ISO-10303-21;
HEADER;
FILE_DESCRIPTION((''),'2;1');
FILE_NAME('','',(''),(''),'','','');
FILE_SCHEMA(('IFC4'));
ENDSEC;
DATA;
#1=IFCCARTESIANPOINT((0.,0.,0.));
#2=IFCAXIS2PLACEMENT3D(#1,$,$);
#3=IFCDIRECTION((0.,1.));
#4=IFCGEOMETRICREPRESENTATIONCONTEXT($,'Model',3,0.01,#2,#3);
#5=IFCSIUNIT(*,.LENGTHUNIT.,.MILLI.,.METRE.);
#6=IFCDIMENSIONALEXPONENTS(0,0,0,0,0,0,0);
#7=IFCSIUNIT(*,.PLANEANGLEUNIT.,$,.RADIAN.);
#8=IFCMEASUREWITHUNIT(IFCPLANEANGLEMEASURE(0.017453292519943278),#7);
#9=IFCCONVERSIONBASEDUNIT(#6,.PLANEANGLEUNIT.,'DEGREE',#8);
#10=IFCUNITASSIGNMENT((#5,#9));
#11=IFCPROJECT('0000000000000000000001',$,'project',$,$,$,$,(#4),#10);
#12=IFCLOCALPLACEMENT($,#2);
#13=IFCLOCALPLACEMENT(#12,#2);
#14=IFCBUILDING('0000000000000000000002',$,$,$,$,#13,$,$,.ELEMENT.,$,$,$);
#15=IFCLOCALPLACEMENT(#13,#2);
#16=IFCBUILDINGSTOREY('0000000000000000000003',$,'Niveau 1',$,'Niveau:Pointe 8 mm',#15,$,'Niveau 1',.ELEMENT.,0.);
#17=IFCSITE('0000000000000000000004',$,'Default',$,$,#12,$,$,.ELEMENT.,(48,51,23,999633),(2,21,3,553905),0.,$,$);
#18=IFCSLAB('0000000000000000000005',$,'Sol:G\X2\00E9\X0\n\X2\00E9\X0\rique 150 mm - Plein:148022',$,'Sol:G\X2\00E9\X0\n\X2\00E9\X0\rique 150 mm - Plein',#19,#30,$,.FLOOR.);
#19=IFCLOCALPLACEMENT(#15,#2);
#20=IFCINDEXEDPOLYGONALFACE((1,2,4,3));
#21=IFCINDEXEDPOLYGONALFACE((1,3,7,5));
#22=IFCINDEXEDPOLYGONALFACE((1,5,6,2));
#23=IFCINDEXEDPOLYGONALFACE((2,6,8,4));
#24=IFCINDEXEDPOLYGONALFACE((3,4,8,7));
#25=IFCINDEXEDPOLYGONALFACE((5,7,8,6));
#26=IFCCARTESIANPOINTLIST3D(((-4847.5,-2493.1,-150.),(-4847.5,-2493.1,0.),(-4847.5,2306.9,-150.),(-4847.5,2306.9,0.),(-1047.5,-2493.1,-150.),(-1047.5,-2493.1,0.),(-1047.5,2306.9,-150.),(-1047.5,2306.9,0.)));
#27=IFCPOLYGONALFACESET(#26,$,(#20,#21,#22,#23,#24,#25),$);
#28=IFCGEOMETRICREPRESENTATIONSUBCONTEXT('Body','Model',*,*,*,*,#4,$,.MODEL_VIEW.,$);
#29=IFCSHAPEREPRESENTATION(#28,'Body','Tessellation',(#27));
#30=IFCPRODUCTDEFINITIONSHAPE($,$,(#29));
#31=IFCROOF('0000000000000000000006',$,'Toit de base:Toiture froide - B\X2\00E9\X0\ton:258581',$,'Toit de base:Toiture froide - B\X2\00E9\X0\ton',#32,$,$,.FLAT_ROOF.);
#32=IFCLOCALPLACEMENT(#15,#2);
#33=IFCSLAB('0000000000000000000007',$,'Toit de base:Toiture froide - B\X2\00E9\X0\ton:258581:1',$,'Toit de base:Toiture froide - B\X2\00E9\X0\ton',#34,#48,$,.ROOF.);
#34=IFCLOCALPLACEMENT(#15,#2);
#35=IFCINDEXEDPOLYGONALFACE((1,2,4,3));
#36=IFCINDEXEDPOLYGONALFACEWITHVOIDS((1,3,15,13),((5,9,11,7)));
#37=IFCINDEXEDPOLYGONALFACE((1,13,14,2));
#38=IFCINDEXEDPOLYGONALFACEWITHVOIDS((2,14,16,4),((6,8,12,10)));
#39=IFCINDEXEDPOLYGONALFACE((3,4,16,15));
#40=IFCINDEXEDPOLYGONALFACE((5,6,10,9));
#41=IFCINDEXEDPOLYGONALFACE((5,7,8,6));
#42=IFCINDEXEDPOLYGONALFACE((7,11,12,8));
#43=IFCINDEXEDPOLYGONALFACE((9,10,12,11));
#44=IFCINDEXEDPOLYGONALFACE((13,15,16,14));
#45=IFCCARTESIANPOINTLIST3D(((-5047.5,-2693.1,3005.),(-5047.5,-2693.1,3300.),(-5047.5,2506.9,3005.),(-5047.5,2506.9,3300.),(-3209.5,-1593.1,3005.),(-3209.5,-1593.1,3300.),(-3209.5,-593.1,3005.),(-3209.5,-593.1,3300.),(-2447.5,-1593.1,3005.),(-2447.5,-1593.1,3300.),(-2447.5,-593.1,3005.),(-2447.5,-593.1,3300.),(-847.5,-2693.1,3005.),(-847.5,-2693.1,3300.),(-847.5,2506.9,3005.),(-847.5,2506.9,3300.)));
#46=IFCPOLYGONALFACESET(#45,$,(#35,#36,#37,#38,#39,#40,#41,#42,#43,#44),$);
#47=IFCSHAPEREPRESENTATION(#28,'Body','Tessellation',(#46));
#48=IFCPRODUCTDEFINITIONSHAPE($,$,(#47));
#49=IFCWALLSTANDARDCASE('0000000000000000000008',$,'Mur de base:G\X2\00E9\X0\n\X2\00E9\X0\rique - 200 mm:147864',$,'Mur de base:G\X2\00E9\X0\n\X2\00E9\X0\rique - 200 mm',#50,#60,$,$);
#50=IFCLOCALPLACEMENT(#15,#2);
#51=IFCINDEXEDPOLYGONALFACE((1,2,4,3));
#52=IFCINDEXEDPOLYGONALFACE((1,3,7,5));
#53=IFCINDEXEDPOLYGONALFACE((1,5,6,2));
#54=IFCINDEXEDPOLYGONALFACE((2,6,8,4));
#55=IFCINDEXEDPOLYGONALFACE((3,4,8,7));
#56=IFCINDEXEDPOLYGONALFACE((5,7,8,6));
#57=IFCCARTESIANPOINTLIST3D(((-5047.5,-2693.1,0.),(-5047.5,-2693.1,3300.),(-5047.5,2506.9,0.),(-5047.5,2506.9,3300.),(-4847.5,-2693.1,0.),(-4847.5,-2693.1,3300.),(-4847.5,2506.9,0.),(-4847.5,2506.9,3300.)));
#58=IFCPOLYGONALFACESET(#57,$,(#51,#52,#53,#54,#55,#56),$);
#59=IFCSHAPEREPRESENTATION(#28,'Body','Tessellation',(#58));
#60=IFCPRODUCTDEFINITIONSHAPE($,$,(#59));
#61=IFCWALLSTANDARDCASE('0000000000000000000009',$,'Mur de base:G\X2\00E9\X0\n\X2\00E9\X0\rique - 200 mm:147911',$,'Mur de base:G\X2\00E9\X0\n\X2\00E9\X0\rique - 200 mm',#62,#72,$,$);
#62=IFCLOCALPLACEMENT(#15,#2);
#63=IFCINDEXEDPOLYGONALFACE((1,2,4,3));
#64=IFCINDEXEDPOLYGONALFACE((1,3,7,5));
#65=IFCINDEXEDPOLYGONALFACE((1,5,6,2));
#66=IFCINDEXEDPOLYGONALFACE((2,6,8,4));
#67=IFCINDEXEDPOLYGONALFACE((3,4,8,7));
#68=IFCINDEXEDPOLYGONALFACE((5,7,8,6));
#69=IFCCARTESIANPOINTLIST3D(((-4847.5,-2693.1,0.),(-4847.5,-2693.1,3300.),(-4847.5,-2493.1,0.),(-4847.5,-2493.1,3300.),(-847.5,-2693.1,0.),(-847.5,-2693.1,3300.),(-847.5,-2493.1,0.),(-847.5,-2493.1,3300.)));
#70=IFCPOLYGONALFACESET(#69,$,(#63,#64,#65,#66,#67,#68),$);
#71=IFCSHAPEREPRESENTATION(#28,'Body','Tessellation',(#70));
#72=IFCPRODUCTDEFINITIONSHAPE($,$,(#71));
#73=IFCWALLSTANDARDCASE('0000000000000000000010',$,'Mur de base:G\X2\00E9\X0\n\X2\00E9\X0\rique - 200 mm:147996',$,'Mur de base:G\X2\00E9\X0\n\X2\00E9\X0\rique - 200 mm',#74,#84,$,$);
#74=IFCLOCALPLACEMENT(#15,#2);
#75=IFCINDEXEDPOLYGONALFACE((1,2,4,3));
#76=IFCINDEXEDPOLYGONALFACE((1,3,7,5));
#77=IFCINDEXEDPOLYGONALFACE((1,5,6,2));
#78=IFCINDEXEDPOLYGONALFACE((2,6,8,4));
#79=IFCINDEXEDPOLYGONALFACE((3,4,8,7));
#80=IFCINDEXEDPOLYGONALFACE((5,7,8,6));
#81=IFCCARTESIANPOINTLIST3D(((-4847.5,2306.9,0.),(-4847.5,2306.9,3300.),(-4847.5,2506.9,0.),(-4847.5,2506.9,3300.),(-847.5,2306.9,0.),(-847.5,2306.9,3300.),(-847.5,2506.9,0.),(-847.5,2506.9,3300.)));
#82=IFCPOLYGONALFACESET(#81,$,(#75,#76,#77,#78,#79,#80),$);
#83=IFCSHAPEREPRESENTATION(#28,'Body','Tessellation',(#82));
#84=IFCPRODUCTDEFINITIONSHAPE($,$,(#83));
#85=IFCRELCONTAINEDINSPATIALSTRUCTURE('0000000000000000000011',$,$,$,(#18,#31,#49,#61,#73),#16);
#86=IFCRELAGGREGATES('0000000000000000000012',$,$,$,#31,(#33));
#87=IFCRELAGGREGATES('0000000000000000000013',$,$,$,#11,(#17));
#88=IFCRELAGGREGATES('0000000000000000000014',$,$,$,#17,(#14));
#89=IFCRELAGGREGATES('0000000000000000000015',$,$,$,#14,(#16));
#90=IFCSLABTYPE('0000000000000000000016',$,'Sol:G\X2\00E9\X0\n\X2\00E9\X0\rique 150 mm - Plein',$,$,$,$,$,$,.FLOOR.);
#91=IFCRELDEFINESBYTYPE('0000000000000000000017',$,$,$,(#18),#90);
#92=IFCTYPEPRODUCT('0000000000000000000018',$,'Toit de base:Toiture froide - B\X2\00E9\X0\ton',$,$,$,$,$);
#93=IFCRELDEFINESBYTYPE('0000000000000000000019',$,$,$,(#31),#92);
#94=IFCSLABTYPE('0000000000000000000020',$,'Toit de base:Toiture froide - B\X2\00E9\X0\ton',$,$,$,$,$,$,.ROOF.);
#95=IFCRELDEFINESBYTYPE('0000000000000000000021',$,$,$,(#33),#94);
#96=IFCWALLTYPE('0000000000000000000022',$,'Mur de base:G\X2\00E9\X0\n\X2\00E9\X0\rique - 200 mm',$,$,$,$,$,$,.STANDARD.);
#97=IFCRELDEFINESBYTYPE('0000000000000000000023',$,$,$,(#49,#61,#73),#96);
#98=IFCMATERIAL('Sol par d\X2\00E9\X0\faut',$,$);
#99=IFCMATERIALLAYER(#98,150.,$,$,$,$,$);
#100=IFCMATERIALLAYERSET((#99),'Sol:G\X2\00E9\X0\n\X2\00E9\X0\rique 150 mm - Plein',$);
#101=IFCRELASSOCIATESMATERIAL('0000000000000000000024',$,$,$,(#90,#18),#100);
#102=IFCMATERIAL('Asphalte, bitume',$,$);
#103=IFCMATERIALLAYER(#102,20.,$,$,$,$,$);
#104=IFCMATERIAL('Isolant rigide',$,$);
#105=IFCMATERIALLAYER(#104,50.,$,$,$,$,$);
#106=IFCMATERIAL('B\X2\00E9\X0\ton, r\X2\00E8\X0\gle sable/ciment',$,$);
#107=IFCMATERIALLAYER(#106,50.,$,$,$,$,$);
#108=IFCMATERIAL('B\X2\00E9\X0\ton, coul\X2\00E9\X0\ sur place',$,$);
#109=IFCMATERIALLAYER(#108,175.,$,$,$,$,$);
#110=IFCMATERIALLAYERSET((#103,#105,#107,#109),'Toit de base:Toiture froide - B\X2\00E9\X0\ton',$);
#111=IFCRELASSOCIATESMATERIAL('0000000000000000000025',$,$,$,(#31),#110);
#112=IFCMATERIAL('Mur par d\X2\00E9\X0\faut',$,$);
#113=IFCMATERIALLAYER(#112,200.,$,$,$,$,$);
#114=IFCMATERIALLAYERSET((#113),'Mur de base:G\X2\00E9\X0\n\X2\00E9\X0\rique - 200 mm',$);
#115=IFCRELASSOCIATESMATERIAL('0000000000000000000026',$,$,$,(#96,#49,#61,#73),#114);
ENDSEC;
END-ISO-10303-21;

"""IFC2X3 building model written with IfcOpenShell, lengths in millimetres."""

from ifc_helpers import new_model, entity, si_unit, converted_unit, direction, frame, frame_2d, origin, origin_2d_with_axis, place, context, subcontext, project, spatial, rectangle, extrude, material, layer, layer_set, layer_usage, type_object, element, aggregate, save


model = new_model("IFC2X3")

# Units and contexts
model_context = context("Model", 3, precision=0.01, world=origin(), true_north=direction((0.0, 1.0)))
body_context = subcontext(model_context, "Body", "Model", "MODEL_VIEW")
ifc_project = project(units=[si_unit("LENGTHUNIT", "METRE", prefix="MILLI"), converted_unit("PLANEANGLEUNIT", "DEGREE", entity("IfcPlaneAngleMeasure", 0.017453292519943278), si_unit("PLANEANGLEUNIT", "RADIAN"), dimensions=[0, 0, 0, 0, 0, 0, 0])], contexts=[model_context])

# Site, building, storey
site_placement = place(None, origin())
site = spatial("IfcSite", under=ifc_project, at=site_placement, Name="Default", CompositionType="ELEMENT", RefLatitude=(48, 51, 23, 999633), RefLongitude=(2, 21, 3, 553905), RefElevation=0.0)
building_placement = place(site_placement, origin())
building = spatial("IfcBuilding", under=site, at=building_placement, CompositionType="ELEMENT")
storey_placement = place(building_placement, origin())
storey = spatial("IfcBuildingStorey", under=building, at=storey_placement, Name="Niveau 1", ObjectType="Niveau:Pointe 8 mm", LongName="Niveau 1", CompositionType="ELEMENT", Elevation=0.0)

# Slab
ifc_material_1 = material(Name="Sol par défaut")
ifc_layer_1 = layer(ifc_material_1, 150.0)
ifc_layer_set_1 = layer_set([ifc_layer_1], Name="Sol:Générique 150 mm - Plein")
ifc_layer_usage_1 = layer_usage(ifc_layer_set_1, "AXIS3", "POSITIVE", 0.0)
slab_type_1 = type_object("IfcSlabType", Name="Sol:Générique 150 mm - Plein", PredefinedType="FLOOR", material=ifc_layer_set_1)
slab_1_placement = place(storey_placement, origin())
element("IfcSlab", 1, at=slab_1_placement, inside=storey, type_object=slab_type_1, material=ifc_layer_usage_1, Name="Sol:Générique 150 mm - Plein:148022", ObjectType="Sol:Générique 150 mm - Plein", PredefinedType="FLOOR", context=body_context, shape_type="SweptSolid", body=[
    extrude(rectangle(XDim=4800.0, YDim=3800.0, at=frame_2d((0.0, 0.0), x_axis=(1.0, 0.0))), frame((-2947.5, -93.1, 0.0), z_axis=(0.0, 0.0, -1.0), x_axis=(0.0, 1.0, 0.0)), (0.0, 0.0, 1.0), 150.0),
])

# Roof, slab, opening
ifc_material_2 = material(Name="Asphalte, bitume")
ifc_layer_2 = layer(ifc_material_2, 20.0)
ifc_material_3 = material(Name="Isolant rigide")
ifc_layer_3 = layer(ifc_material_3, 50.0)
ifc_material_4 = material(Name="Béton, règle sable/ciment")
ifc_layer_4 = layer(ifc_material_4, 50.0)
ifc_material_5 = material(Name="Béton, coulé sur place")
ifc_layer_5 = layer(ifc_material_5, 175.0)
ifc_layer_set_2 = layer_set([ifc_layer_2, ifc_layer_3, ifc_layer_4, ifc_layer_5], Name="Toit de base:Toiture froide - Béton")
type_product = type_object("IfcTypeProduct", Name="Toit de base:Toiture froide - Béton")
roof_placement = place(storey_placement, origin())
roof = element("IfcRoof", 2, at=roof_placement, inside=storey, type_object=type_product, material=ifc_layer_set_2, Name="Toit de base:Toiture froide - Béton:258581", ObjectType="Toit de base:Toiture froide - Béton", ShapeType="FLAT_ROOF")
slab_type_2 = type_object("IfcSlabType", Name="Toit de base:Toiture froide - Béton", PredefinedType="ROOF")
slab_2_placement = place(storey_placement, origin())
slab_2 = element("IfcSlab", 3, at=slab_2_placement, type_object=slab_type_2, Name="Toit de base:Toiture froide - Béton:258581:1", ObjectType="Toit de base:Toiture froide - Béton", PredefinedType="ROOF", context=body_context, shape_type="SweptSolid", body=[
    extrude(rectangle(XDim=5200.0, YDim=4200.0, at=frame_2d((0.0, 0.0), x_axis=(1.0, 0.0))), frame((-2947.5, -93.1, 3005.0), z_axis=(0.0, 0.0, 1.0), x_axis=(0.0, 1.0, 0.0)), (0.0, 0.0, 1.0), 295.0),
])
opening_1_placement = place(storey_placement, origin())
element("IfcOpeningElement", 4, at=opening_1_placement, cuts=slab_2, ObjectType="Opening", context=body_context, shape_type="SweptSolid", body=[
    extrude(rectangle(XDim=762.0, YDim=1000.0, at=origin_2d_with_axis()), frame((-2828.5, -1093.1, 3005.0), z_axis=(0.0, 0.0, 1.0), x_axis=(-1.0, 0.0, 0.0)), (0.0, 0.0, 1.0), 295.0),
])
aggregate(roof, [slab_2])

# Walls
ifc_material_6 = material(Name="Mur par défaut")
ifc_layer_6 = layer(ifc_material_6, 200.0)
ifc_layer_set_3 = layer_set([ifc_layer_6], Name="Mur de base:Générique - 200 mm")
ifc_layer_usage_2 = layer_usage(ifc_layer_set_3, "AXIS2", "NEGATIVE", 100.0)
wall_type = type_object("IfcWallType", Name="Mur de base:Générique - 200 mm", PredefinedType="STANDARD", material=ifc_layer_set_3)
wall_1_placement = place(storey_placement, frame((-4947.5, 2506.9, 0.0), z_axis=(0.0, 0.0, 1.0), x_axis=(0.0, -1.0, 0.0)))
element("IfcWallStandardCase", 5, at=wall_1_placement, inside=storey, type_object=wall_type, material=ifc_layer_usage_2, Name="Mur de base:Générique - 200 mm:147864", ObjectType="Mur de base:Générique - 200 mm", context=body_context, shape_type="SweptSolid", body=[
    extrude(rectangle(XDim=5200.0, YDim=200.0, at=frame_2d((2600.0, 0.0), x_axis=(-1.0, 0.0))), origin(), (0.0, 0.0, 1.0), 3300.0),
])
ifc_layer_usage_3 = layer_usage(ifc_layer_set_3, "AXIS2", "NEGATIVE", 100.0)
wall_2_placement = place(storey_placement, frame((-4847.5, -2593.1, 0.0)))
element("IfcWallStandardCase", 6, at=wall_2_placement, inside=storey, type_object=wall_type, material=ifc_layer_usage_3, Name="Mur de base:Générique - 200 mm:147911", ObjectType="Mur de base:Générique - 200 mm", context=body_context, shape_type="SweptSolid", body=[
    extrude(rectangle(XDim=4000.0, YDim=200.0, at=frame_2d((2000.0, 0.0), x_axis=(-1.0, 0.0))), origin(), (0.0, 0.0, 1.0), 3300.0),
])
ifc_layer_usage_4 = layer_usage(ifc_layer_set_3, "AXIS2", "NEGATIVE", 100.0)
wall_3_placement = place(storey_placement, frame((-847.5, 2406.9, 0.0), z_axis=(0.0, 0.0, 1.0), x_axis=(-1.0, 0.0, 0.0)))
element("IfcWallStandardCase", 7, at=wall_3_placement, inside=storey, type_object=wall_type, material=ifc_layer_usage_4, Name="Mur de base:Générique - 200 mm:147996", ObjectType="Mur de base:Générique - 200 mm", context=body_context, shape_type="SweptSolid", body=[
    extrude(rectangle(XDim=4000.0, YDim=200.0, at=frame_2d((2000.0, 0.0), x_axis=(-1.0, 0.0))), origin(), (0.0, 0.0, 1.0), 3300.0),
])

save(model, "model.ifc")
